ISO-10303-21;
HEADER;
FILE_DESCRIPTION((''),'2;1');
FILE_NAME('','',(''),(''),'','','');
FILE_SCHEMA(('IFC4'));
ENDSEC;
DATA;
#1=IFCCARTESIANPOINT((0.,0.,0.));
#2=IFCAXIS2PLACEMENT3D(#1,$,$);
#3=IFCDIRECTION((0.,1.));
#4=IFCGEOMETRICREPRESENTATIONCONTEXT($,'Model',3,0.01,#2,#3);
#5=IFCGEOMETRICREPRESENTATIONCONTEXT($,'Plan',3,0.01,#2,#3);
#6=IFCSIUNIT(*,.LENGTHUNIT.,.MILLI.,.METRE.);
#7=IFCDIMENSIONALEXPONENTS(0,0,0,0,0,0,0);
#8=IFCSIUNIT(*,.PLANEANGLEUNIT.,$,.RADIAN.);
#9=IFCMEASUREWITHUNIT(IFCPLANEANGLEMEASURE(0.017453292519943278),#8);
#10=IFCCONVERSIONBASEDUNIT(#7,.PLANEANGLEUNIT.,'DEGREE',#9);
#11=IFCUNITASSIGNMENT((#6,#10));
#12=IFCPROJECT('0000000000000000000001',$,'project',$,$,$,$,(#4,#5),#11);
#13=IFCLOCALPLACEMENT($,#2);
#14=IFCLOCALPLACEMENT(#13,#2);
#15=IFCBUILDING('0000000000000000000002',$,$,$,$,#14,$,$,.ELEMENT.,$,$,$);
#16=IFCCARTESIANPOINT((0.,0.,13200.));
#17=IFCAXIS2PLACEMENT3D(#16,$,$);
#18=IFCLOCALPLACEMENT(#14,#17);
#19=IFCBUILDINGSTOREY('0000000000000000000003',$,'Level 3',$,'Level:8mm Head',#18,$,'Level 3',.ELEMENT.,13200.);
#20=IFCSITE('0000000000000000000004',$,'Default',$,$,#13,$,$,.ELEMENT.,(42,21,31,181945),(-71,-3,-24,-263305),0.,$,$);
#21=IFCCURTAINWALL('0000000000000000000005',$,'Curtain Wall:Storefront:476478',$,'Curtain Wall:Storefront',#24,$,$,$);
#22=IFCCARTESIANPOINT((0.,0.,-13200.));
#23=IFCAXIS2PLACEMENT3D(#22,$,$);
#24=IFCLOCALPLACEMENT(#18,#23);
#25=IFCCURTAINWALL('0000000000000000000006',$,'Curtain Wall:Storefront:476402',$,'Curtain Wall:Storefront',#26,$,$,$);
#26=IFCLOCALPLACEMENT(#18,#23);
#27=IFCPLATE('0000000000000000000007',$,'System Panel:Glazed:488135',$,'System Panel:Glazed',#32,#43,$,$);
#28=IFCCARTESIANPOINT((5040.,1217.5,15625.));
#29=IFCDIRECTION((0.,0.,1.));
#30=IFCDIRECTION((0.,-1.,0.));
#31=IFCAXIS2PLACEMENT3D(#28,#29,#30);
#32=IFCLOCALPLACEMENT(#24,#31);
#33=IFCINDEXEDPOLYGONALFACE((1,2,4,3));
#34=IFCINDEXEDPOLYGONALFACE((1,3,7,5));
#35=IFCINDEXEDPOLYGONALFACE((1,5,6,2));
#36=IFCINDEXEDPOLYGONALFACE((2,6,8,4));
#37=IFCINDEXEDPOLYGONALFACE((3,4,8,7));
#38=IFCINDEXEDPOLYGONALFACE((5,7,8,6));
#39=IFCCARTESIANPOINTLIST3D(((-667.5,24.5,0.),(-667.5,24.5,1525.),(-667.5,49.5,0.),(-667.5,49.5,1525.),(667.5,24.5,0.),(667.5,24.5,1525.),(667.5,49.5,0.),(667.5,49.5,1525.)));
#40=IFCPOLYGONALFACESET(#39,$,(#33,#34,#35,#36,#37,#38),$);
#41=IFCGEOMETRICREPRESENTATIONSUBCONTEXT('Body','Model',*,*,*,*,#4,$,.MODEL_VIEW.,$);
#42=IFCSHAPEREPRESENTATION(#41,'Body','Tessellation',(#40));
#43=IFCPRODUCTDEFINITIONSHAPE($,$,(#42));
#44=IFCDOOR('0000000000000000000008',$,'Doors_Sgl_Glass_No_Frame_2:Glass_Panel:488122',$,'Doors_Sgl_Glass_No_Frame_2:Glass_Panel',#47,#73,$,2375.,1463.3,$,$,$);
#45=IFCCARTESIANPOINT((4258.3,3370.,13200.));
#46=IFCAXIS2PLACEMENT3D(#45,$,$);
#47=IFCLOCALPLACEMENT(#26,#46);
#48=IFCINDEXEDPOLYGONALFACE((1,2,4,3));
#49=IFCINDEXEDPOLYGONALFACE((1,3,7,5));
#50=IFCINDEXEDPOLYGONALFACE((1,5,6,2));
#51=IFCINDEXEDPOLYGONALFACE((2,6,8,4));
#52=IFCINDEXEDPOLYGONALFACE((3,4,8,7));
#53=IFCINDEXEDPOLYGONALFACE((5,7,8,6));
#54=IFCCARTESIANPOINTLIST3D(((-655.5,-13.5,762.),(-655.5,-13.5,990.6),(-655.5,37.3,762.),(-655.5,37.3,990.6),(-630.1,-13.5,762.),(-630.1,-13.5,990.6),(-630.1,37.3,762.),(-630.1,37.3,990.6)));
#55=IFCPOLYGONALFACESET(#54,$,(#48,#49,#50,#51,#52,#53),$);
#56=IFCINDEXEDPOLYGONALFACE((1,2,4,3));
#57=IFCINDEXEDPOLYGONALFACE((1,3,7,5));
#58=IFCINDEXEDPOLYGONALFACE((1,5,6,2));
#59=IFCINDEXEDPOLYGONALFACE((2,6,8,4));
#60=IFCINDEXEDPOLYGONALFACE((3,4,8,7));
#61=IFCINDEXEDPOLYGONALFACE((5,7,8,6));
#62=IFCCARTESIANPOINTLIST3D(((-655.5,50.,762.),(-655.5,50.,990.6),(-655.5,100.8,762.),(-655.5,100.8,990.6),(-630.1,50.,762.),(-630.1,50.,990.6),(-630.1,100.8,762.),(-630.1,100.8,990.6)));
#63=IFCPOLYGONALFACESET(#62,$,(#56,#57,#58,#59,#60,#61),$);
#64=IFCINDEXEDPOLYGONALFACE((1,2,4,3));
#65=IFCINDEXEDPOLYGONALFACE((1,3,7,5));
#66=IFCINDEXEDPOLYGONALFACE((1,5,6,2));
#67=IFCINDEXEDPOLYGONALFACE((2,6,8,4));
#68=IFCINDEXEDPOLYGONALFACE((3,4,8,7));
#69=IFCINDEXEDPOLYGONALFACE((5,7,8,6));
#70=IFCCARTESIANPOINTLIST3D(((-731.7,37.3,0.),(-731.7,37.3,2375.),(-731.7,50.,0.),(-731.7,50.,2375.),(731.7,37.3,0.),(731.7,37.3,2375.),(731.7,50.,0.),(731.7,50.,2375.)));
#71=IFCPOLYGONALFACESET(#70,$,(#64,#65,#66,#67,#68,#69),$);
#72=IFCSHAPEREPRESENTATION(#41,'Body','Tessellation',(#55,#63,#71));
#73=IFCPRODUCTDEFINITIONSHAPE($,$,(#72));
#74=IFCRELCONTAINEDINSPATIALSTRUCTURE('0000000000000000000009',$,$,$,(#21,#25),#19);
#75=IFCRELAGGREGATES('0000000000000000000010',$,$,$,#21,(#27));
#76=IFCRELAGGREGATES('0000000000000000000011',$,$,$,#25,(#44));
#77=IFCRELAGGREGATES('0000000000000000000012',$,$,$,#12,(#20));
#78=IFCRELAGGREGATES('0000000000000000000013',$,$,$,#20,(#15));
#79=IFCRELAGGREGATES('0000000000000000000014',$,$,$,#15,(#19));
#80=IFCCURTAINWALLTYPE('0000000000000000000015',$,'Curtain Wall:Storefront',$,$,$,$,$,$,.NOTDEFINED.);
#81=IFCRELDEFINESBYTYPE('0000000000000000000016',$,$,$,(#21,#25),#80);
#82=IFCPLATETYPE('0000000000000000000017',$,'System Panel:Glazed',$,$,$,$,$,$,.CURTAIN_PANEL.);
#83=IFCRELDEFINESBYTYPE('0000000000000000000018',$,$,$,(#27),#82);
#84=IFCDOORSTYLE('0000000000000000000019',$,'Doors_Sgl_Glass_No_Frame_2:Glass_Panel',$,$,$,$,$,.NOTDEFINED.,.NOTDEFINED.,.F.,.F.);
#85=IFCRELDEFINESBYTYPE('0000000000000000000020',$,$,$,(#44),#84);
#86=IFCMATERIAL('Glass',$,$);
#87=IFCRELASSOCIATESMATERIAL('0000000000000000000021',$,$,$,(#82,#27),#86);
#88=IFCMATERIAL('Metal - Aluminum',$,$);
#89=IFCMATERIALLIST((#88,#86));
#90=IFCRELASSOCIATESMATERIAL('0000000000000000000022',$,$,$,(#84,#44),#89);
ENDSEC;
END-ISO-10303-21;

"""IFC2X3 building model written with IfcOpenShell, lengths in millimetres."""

from ifc_helpers import new_model, entity, si_unit, converted_unit, direction, frame, frame_2d, origin, origin_2d_with_axis, place, context, subcontext, project, spatial, rectangle, extrude, source, transform, mapped, material, material_list, type_object, type_shapes, element, aggregate, save


model = new_model("IFC2X3")

# Units and contexts
model_context = context("Model", 3, precision=0.01, world=origin(), true_north=direction((0.0, 1.0)))
plan_context = context("Plan", 3, precision=0.01, world=origin(), true_north=direction((0.0, 1.0)))
body_context = subcontext(model_context, "Body", "Model", "MODEL_VIEW")
ifc_project = project(units=[si_unit("LENGTHUNIT", "METRE", prefix="MILLI"), converted_unit("PLANEANGLEUNIT", "DEGREE", entity("IfcPlaneAngleMeasure", 0.017453292519943278), si_unit("PLANEANGLEUNIT", "RADIAN"), dimensions=[0, 0, 0, 0, 0, 0, 0])], contexts=[model_context, plan_context])

# Site, building, storey
site_placement = place(None, origin())
site = spatial("IfcSite", under=ifc_project, at=site_placement, Name="Default", CompositionType="ELEMENT", RefLatitude=(42, 21, 31, 181945), RefLongitude=(-71, -3, -24, -263305), RefElevation=0.0)
building_placement = place(site_placement, origin())
building = spatial("IfcBuilding", under=site, at=building_placement, CompositionType="ELEMENT")
storey_placement = place(building_placement, frame((0.0, 0.0, 13200.0)))
storey = spatial("IfcBuildingStorey", under=building, at=storey_placement, Name="Level 3", ObjectType="Level:8mm Head", LongName="Level 3", CompositionType="ELEMENT", Elevation=13200.0)

# Curtain walls
curtain_wall_type = type_object("IfcCurtainWallType", Name="Curtain Wall:Storefront", PredefinedType="NOTDEFINED")
curtain_wall_1_placement = place(storey_placement, frame((0.0, 0.0, -13200.0)))
curtain_wall_1 = element("IfcCurtainWall", 1, at=curtain_wall_1_placement, inside=storey, type_object=curtain_wall_type, Name="Curtain Wall:Storefront:476478", ObjectType="Curtain Wall:Storefront")
curtain_wall_2_placement = place(storey_placement, frame((0.0, 0.0, -13200.0)))
curtain_wall_2 = element("IfcCurtainWall", 2, at=curtain_wall_2_placement, inside=storey, type_object=curtain_wall_type, Name="Curtain Wall:Storefront:476402", ObjectType="Curtain Wall:Storefront")

# Plate
ifc_material_1 = material(Name="Glass")
plate_type_1 = type_object("IfcPlateType", Name="System Panel:Glazed", PredefinedType="CURTAIN_PANEL", material=ifc_material_1)
shared_shape_1 = source(origin(), body_context, "Body", "SweptSolid", [
    extrude(rectangle(XDim=25.0, YDim=1335.0, at=origin_2d_with_axis()), frame((0.0, 37.0, 0.0), z_axis=(0.0, 0.0, 1.0), x_axis=(0.0, 1.0, 0.0)), (0.0, 0.0, 1.0), 1525.0),
])
type_shapes(plate_type_1, [shared_shape_1])
plate_1_placement = place(curtain_wall_1_placement, frame((5040.0, 1217.5, 15625.0), z_axis=(0.0, 0.0, 1.0), x_axis=(0.0, -1.0, 0.0)))
plate_1 = element("IfcPlate", 3, at=plate_1_placement, type_object=plate_type_1, material=ifc_material_1, Name="System Panel:Glazed:488135", ObjectType="System Panel:Glazed", context=body_context, shape_type="MappedRepresentation", body=[
    mapped(shared_shape_1, transform((0.0, 0.0, 0.0), scale=1.0)),
])
aggregate(curtain_wall_1, [plate_1])

# Door
ifc_material_2 = material(Name="Metal - Aluminum")
ifc_material_list = material_list([ifc_material_2, ifc_material_1])
door_style = type_object("IfcDoorStyle", Name="Doors_Sgl_Glass_No_Frame_2:Glass_Panel", ConstructionType="NOTDEFINED", OperationType="NOTDEFINED", ParameterTakesPrecedence=False, Sizeable=False, material=ifc_material_list)
shared_shape_2 = source(origin(), body_context, "Body", "SweptSolid", [
    extrude(rectangle(XDim=50.8, YDim=25.4, at=frame_2d((0.0, 0.0), x_axis=(1.0, 0.0))), frame((-642.8, 11.9, 762.0), z_axis=(0.0, 0.0, 1.0), x_axis=(0.0, 1.0, 0.0)), (0.0, 0.0, 1.0), 228.6),
    extrude(rectangle(XDim=50.8, YDim=25.4, at=frame_2d((0.0, 0.0), x_axis=(1.0, 0.0))), frame((-642.8, 75.4, 762.0), z_axis=(0.0, 0.0, 1.0), x_axis=(0.0, -1.0, 0.0)), (0.0, 0.0, 1.0), 228.6),
    extrude(rectangle(XDim=1463.3, YDim=12.7, at=frame_2d((0.0, 0.0), x_axis=(1.0, 0.0))), frame((0.0, 43.7, 0.0), z_axis=(0.0, 0.0, 1.0), x_axis=(-1.0, 0.0, 0.0)), (0.0, 0.0, 1.0), 2375.0),
])
type_shapes(door_style, [shared_shape_2])
door_placement = place(curtain_wall_2_placement, frame((4258.3, 3370.0, 13200.0)))
door = element("IfcDoor", 4, at=door_placement, type_object=door_style, material=ifc_material_list, Name="Doors_Sgl_Glass_No_Frame_2:Glass_Panel:488122", ObjectType="Doors_Sgl_Glass_No_Frame_2:Glass_Panel", OverallHeight=2375.0, OverallWidth=1463.3, context=body_context, shape_type="MappedRepresentation", body=[
    mapped(shared_shape_2, transform((0.0, 0.0, 0.0), scale=1.0)),
])
aggregate(curtain_wall_2, [door])

save(model, "model.ifc")
